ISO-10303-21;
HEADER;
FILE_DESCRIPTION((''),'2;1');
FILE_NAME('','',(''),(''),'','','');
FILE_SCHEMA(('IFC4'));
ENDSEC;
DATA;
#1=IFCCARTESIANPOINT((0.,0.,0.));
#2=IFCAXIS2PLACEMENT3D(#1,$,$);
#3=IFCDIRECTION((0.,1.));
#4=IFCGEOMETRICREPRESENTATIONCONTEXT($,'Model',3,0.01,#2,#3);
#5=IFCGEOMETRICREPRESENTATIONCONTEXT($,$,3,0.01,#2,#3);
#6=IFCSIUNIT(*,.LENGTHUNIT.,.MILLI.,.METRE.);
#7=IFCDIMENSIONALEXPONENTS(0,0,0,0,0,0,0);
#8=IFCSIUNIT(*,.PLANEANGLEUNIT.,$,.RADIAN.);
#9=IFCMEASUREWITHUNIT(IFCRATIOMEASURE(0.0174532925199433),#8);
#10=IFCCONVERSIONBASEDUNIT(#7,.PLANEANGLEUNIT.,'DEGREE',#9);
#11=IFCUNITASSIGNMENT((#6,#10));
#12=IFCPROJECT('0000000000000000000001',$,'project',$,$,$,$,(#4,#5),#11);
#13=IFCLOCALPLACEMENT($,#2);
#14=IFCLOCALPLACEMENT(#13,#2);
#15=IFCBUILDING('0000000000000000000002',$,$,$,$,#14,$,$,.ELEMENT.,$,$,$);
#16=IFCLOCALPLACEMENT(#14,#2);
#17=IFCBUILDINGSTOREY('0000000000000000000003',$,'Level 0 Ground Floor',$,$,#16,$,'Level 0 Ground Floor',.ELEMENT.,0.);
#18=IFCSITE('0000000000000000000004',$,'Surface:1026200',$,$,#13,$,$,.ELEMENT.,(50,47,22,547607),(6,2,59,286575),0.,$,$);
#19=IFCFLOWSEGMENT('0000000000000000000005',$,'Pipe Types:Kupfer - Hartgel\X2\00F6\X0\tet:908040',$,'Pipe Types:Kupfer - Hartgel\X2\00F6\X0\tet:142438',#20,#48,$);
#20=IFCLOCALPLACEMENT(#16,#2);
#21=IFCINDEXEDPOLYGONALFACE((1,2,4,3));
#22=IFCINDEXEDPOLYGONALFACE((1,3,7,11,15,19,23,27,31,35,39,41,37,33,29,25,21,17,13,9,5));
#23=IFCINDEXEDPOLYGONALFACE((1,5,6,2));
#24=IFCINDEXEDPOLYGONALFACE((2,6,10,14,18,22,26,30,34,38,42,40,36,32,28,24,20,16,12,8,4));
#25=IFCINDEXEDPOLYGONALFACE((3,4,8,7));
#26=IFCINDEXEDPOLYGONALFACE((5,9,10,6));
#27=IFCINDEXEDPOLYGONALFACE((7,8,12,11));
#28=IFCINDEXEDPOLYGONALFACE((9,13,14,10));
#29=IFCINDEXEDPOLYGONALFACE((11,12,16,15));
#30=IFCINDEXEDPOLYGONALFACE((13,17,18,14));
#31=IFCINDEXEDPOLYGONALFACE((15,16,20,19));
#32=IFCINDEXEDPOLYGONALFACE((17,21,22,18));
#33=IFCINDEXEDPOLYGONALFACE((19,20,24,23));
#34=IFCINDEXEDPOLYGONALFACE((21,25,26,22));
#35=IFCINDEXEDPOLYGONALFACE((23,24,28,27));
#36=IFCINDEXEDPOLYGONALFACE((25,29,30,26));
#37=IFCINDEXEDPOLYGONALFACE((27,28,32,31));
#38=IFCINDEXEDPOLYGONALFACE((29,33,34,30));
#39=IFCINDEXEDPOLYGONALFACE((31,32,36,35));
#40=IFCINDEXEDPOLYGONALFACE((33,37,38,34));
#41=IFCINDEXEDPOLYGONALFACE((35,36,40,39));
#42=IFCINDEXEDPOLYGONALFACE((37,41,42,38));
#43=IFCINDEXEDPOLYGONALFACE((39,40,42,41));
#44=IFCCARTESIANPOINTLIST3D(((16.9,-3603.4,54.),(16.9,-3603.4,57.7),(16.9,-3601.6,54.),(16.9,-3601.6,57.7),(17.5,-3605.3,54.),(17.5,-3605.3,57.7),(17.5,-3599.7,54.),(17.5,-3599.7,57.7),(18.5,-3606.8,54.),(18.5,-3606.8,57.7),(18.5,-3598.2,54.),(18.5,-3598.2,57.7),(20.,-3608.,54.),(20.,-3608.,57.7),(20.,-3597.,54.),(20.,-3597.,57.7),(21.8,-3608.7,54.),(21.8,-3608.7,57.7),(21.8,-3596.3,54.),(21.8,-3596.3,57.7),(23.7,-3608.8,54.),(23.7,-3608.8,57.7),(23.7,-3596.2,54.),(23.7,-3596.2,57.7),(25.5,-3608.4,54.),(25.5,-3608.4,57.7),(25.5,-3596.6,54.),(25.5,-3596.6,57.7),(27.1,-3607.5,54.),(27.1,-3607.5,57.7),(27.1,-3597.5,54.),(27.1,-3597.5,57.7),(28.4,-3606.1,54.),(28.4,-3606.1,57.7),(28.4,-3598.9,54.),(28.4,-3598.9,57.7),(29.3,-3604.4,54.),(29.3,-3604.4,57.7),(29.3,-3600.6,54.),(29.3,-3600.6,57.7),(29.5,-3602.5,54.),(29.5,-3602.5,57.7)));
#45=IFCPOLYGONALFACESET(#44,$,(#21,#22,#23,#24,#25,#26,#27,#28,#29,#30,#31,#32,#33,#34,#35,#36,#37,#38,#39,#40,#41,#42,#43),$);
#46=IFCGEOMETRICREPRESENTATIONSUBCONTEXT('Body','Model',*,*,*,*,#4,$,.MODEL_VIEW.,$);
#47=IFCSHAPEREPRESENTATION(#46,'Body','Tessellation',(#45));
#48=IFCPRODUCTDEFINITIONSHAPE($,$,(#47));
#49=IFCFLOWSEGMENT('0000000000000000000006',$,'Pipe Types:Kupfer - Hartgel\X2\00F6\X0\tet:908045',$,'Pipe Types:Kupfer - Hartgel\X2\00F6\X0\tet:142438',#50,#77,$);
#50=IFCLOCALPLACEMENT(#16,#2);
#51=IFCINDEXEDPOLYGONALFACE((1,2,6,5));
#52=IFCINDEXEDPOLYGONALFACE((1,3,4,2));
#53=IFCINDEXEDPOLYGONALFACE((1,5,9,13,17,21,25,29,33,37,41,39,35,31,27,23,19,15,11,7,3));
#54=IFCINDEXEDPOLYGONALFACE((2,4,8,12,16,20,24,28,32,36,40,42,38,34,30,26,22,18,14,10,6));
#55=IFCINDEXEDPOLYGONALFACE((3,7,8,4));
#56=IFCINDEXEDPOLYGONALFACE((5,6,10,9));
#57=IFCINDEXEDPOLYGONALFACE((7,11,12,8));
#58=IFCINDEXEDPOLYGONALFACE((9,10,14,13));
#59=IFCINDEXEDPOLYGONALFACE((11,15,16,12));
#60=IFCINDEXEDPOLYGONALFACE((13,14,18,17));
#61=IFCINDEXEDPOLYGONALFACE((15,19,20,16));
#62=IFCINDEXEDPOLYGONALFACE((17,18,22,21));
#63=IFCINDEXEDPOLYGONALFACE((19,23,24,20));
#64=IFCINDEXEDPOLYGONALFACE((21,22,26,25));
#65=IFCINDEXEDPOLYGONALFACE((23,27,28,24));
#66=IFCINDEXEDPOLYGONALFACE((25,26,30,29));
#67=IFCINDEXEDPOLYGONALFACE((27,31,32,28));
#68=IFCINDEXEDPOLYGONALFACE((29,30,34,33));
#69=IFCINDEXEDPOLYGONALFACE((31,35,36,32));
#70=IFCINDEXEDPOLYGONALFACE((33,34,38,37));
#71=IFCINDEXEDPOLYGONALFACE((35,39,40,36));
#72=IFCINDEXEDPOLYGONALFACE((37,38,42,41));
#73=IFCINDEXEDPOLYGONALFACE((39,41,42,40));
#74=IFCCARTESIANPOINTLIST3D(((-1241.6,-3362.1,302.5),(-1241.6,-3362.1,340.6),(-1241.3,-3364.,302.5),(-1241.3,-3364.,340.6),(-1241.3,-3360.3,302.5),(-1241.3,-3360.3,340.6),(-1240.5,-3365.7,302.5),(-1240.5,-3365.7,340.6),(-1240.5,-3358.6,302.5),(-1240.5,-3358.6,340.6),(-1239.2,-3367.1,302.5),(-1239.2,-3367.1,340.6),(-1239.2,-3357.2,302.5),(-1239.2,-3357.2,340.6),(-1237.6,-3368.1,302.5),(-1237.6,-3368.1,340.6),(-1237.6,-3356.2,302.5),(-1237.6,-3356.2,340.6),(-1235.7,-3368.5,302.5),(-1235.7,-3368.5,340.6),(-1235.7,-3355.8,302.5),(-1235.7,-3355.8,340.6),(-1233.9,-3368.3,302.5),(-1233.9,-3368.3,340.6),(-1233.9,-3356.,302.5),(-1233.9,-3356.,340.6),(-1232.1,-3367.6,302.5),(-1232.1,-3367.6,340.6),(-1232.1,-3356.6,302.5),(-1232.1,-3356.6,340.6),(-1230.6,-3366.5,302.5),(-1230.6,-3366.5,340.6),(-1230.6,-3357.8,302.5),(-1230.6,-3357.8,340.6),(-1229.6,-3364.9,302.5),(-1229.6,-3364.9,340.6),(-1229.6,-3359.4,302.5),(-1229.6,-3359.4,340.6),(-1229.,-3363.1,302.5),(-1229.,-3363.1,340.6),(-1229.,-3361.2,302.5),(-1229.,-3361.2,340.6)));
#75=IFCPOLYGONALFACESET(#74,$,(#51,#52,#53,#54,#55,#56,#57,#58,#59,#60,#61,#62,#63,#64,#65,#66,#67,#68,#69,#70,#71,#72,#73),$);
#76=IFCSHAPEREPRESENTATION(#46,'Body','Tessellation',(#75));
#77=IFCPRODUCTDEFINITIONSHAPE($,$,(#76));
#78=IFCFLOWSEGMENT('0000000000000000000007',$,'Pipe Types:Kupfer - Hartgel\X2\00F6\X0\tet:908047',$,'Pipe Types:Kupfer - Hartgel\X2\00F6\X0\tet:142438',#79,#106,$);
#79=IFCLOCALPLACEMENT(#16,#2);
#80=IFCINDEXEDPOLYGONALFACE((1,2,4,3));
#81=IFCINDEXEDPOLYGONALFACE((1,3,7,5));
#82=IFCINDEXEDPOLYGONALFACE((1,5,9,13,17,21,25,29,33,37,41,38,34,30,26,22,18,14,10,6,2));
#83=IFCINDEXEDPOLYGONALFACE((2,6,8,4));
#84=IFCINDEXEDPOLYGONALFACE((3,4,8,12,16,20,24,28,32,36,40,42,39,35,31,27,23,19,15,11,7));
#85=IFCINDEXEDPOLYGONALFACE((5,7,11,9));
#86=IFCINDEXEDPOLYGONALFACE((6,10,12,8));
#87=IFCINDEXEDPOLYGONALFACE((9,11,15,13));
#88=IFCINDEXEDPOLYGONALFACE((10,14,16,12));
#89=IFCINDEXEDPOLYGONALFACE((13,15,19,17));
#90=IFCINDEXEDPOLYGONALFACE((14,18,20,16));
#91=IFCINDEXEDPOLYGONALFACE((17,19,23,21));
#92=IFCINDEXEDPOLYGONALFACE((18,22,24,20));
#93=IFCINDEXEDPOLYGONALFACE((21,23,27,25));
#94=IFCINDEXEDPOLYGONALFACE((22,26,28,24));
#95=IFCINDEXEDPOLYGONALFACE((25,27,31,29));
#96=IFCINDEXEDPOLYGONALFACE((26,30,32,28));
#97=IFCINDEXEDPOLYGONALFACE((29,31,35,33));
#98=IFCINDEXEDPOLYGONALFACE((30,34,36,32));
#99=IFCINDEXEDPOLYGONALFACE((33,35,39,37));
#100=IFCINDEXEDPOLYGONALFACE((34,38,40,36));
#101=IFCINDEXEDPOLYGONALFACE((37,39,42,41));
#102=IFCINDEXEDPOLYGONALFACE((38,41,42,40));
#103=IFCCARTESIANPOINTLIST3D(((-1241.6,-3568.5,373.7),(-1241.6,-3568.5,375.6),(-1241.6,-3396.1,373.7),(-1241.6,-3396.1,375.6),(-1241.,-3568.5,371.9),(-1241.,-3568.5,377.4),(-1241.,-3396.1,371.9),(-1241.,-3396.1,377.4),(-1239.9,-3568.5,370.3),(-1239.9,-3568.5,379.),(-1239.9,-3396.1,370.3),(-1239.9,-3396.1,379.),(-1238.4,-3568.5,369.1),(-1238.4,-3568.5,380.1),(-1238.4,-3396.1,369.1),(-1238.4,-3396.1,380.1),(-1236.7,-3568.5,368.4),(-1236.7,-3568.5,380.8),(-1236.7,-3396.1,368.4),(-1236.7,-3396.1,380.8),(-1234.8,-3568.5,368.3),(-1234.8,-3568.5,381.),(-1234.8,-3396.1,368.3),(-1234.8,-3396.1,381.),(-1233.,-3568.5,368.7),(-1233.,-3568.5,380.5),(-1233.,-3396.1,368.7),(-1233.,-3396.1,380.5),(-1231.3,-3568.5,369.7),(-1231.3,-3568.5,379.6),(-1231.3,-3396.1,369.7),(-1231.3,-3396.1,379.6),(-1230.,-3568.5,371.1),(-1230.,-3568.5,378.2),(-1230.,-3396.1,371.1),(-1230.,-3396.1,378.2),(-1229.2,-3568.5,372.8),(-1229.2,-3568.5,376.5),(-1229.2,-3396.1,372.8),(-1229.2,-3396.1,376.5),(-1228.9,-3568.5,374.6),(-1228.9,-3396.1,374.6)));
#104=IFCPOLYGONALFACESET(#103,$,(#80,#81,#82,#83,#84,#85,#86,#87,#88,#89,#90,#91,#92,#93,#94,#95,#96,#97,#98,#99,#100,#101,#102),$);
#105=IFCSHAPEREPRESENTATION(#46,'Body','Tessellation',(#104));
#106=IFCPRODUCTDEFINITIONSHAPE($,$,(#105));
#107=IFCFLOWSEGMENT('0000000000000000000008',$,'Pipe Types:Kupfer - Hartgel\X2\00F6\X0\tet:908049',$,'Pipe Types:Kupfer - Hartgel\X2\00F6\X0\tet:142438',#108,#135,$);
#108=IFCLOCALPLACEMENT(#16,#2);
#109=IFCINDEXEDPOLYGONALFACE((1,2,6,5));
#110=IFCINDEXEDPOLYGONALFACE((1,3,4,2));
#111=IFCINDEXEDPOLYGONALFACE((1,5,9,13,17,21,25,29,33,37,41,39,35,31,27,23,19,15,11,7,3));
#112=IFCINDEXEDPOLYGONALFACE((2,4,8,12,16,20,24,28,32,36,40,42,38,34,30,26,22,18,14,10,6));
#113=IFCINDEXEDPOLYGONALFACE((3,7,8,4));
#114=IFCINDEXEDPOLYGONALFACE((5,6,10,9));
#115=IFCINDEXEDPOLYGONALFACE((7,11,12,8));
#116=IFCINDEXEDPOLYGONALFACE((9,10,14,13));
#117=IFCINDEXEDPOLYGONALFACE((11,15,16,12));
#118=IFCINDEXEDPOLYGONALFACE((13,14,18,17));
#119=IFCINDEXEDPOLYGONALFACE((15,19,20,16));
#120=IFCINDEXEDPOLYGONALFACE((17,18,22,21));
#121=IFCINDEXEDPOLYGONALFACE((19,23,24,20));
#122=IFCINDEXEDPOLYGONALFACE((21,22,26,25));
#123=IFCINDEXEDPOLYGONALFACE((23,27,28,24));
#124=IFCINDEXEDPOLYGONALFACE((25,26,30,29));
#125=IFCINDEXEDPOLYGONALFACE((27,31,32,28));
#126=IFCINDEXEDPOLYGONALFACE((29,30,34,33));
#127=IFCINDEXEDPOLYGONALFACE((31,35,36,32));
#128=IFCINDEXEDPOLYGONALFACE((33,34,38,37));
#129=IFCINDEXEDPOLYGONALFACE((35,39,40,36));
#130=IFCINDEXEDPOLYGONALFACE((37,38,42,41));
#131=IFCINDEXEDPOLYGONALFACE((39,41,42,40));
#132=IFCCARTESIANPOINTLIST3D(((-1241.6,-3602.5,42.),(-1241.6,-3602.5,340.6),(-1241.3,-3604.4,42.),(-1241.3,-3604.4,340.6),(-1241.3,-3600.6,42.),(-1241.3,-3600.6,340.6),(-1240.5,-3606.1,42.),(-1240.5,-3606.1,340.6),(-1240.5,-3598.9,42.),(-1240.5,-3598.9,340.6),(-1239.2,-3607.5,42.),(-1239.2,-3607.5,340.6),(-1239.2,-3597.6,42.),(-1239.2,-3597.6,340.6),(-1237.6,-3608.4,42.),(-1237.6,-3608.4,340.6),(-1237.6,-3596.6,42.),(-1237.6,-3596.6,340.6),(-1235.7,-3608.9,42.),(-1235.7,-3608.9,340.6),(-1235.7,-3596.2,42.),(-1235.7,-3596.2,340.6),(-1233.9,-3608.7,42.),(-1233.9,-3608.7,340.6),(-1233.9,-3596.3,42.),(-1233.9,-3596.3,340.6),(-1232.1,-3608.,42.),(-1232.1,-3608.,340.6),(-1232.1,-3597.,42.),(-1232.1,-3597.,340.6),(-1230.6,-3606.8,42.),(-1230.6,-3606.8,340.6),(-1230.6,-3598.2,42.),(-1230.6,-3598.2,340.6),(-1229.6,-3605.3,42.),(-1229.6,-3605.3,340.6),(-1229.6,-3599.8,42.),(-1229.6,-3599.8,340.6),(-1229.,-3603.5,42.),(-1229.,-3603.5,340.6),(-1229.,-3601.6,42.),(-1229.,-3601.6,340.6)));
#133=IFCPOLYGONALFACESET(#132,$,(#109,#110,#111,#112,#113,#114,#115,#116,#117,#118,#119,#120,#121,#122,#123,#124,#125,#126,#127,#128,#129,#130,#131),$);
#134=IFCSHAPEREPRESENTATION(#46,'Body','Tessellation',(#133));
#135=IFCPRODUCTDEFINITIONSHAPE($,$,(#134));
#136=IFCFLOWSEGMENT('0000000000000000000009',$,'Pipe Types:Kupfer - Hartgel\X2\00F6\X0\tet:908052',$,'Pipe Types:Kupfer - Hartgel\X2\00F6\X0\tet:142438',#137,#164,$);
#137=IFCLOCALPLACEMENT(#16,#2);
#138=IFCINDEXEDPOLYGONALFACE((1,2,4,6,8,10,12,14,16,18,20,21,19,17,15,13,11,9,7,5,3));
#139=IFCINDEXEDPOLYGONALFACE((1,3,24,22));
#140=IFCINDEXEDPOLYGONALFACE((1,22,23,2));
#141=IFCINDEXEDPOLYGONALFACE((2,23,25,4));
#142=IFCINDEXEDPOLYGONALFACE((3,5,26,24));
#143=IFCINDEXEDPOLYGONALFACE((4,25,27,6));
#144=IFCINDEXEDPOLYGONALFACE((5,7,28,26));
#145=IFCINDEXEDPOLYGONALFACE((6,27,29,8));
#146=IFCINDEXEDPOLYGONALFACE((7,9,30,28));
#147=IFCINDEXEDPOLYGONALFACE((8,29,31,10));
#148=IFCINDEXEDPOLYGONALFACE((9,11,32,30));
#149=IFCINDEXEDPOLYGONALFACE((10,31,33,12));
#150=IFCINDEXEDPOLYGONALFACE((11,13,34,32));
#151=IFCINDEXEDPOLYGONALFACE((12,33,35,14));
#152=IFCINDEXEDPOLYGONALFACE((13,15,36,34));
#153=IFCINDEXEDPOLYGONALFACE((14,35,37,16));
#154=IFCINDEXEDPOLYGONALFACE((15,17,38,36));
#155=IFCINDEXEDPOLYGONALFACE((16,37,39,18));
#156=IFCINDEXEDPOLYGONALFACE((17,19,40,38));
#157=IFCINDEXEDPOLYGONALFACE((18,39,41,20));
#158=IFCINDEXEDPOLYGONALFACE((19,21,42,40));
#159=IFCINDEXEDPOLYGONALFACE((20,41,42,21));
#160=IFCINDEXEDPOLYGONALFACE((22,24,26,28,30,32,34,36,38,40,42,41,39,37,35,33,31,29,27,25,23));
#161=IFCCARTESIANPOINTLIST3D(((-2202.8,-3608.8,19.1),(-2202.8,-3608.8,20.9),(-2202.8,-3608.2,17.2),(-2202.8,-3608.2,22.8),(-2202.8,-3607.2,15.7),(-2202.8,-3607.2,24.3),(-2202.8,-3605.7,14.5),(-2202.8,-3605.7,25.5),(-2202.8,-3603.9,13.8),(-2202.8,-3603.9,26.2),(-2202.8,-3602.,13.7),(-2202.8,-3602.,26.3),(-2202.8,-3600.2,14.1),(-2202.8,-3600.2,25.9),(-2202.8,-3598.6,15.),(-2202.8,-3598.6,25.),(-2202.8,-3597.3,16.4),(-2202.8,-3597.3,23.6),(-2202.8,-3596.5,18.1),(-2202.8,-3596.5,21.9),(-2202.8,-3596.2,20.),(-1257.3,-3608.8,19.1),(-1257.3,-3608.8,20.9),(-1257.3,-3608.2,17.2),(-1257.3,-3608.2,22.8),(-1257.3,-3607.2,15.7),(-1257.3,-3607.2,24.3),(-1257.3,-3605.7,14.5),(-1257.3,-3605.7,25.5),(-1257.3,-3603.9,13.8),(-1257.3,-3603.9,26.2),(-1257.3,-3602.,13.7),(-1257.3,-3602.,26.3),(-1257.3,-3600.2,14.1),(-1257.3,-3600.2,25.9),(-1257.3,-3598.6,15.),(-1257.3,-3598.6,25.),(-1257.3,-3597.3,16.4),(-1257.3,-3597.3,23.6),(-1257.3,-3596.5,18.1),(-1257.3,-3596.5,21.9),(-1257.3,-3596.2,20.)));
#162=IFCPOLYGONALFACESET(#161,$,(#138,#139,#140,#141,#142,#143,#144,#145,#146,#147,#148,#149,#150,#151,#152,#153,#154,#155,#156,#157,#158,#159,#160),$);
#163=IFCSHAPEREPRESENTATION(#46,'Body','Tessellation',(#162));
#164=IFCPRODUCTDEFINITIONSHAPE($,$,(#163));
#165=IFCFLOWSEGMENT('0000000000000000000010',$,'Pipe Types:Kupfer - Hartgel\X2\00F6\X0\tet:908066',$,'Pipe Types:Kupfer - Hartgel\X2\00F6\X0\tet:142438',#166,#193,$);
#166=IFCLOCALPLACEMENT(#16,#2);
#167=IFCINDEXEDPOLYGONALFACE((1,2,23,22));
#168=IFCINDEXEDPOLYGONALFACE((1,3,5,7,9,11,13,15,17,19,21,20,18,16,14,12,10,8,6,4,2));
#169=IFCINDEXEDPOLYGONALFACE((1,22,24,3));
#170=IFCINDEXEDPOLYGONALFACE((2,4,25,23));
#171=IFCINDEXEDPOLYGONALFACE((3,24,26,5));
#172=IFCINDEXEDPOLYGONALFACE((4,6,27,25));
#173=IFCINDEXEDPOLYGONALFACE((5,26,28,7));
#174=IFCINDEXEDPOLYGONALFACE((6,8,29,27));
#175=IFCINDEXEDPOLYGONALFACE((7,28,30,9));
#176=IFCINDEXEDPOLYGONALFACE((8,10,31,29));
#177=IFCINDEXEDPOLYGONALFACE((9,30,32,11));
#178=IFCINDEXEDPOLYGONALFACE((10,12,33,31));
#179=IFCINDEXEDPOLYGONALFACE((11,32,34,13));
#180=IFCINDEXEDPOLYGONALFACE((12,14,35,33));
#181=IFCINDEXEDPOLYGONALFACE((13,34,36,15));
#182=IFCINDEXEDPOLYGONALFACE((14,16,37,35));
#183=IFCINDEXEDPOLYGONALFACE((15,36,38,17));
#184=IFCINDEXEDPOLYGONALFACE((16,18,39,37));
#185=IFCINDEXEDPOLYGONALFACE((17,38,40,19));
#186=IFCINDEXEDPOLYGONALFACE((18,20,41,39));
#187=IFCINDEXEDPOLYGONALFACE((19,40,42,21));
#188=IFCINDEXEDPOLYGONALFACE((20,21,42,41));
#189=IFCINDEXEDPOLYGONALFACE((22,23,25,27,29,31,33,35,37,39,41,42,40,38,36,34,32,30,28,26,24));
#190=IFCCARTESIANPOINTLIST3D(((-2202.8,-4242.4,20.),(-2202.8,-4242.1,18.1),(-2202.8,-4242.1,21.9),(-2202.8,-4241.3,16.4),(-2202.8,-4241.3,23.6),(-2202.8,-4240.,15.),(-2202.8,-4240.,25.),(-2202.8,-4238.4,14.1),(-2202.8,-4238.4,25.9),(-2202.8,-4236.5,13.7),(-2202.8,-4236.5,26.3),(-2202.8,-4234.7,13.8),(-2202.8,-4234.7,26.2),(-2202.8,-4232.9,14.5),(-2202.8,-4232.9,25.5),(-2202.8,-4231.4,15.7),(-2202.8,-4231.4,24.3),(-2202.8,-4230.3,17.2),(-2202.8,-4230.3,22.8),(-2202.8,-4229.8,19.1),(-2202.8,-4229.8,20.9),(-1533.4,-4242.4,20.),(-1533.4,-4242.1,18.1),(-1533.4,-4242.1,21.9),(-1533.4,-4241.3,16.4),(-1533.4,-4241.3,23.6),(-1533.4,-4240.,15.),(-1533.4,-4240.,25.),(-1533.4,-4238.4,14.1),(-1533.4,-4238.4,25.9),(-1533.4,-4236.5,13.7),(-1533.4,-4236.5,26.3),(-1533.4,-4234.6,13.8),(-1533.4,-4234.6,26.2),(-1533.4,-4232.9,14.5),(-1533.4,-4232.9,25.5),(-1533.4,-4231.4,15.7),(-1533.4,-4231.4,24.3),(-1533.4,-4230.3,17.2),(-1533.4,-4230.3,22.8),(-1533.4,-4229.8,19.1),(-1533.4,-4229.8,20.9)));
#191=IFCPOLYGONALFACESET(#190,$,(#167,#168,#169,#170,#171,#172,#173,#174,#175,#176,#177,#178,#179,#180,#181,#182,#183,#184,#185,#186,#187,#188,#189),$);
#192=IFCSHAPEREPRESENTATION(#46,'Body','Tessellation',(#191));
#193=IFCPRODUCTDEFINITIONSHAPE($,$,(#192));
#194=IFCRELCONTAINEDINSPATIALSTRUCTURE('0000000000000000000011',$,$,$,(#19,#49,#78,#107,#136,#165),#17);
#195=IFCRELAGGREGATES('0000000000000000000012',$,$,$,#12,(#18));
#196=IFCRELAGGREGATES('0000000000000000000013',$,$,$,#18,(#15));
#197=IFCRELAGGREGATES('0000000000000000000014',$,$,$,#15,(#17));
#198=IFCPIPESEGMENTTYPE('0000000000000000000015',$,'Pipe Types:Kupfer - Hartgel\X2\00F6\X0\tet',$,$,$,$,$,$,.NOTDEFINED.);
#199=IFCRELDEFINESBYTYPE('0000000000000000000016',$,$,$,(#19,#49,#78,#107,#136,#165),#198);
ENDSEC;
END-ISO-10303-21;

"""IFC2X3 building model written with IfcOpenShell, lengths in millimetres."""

from ifc_helpers import new_model, entity, si_unit, converted_unit, direction, frame, frame_2d, origin, origin_2d_with_axis, place, context, subcontext, project, spatial, circle, extrude, type_object, element, save


model = new_model("IFC2X3")

# Units and contexts
model_context = context("Model", 3, precision=0.01, world=origin(), true_north=direction((0.0, 1.0)))
context_of_model = context(None, 3, precision=0.01, world=origin(), true_north=direction((0.0, 1.0)))
body_context = subcontext(model_context, "Body", "Model", "MODEL_VIEW")
ifc_project = project(units=[si_unit("LENGTHUNIT", "METRE", prefix="MILLI"), converted_unit("PLANEANGLEUNIT", "DEGREE", entity("IfcRatioMeasure", 0.0174532925199433), si_unit("PLANEANGLEUNIT", "RADIAN"), dimensions=[0, 0, 0, 0, 0, 0, 0])], contexts=[model_context, context_of_model])

# Site, building, storey
site_placement = place(None, origin())
site = spatial("IfcSite", under=ifc_project, at=site_placement, Name="Surface:1026200", CompositionType="ELEMENT", RefLatitude=(50, 47, 22, 547607), RefLongitude=(6, 2, 59, 286575), RefElevation=0.0)
building_placement = place(site_placement, origin())
building = spatial("IfcBuilding", under=site, at=building_placement, CompositionType="ELEMENT")
storey_placement = place(building_placement, origin())
storey = spatial("IfcBuildingStorey", under=building, at=storey_placement, Name="Level 0 Ground Floor", LongName="Level 0 Ground Floor", CompositionType="ELEMENT", Elevation=0.0)

# Flow segments
pipe_segment_type = type_object("IfcPipeSegmentType", Name="Pipe Types:Kupfer - Hartgelötet", PredefinedType="NOTDEFINED")
flow_segment_1_placement = place(storey_placement, origin())
element("IfcFlowSegment", 1, at=flow_segment_1_placement, inside=storey, type_object=pipe_segment_type, Name="Pipe Types:Kupfer - Hartgelötet:908040", ObjectType="Pipe Types:Kupfer - Hartgelötet:142438", context=body_context, shape_type="SweptSolid", body=[
    extrude(circle(Radius=6.3, at=frame_2d((0.0, 0.0), x_axis=(1.0, 0.0))), frame((23.2, -3602.5, 54.0)), (0.0, 0.0, 1.0), 3.7),
])
flow_segment_2_placement = place(storey_placement, origin())
element("IfcFlowSegment", 2, at=flow_segment_2_placement, inside=storey, type_object=pipe_segment_type, Name="Pipe Types:Kupfer - Hartgelötet:908045", ObjectType="Pipe Types:Kupfer - Hartgelötet:142438", context=body_context, shape_type="SweptSolid", body=[
    extrude(circle(Radius=6.3, at=origin_2d_with_axis()), frame((-1235.3, -3362.1, 302.5), z_axis=(0.0, 0.0, 1.0), x_axis=(-1.0, 0.0, 0.0)), (0.0, 0.0, 1.0), 38.1),
])
flow_segment_3_placement = place(storey_placement, origin())
element("IfcFlowSegment", 3, at=flow_segment_3_placement, inside=storey, type_object=pipe_segment_type, Name="Pipe Types:Kupfer - Hartgelötet:908047", ObjectType="Pipe Types:Kupfer - Hartgelötet:142438", context=body_context, shape_type="SweptSolid", body=[
    extrude(circle(Radius=6.3, at=frame_2d((0.0, 0.0), x_axis=(1.0, 0.0))), frame((-1235.3, -3568.5, 374.6), z_axis=(0.0, 1.0, 0.0), x_axis=(1.0, 0.0, 0.0)), (0.0, 0.0, 1.0), 172.4),
])
flow_segment_4_placement = place(storey_placement, origin())
element("IfcFlowSegment", 4, at=flow_segment_4_placement, inside=storey, type_object=pipe_segment_type, Name="Pipe Types:Kupfer - Hartgelötet:908049", ObjectType="Pipe Types:Kupfer - Hartgelötet:142438", context=body_context, shape_type="SweptSolid", body=[
    extrude(circle(Radius=6.3, at=frame_2d((0.0, 0.0), x_axis=(1.0, 0.0))), frame((-1235.3, -3602.5, 42.0), z_axis=(0.0, 0.0, 1.0), x_axis=(-1.0, 0.0, 0.0)), (0.0, 0.0, 1.0), 298.6),
])
flow_segment_5_placement = place(storey_placement, origin())
element("IfcFlowSegment", 5, at=flow_segment_5_placement, inside=storey, type_object=pipe_segment_type, Name="Pipe Types:Kupfer - Hartgelötet:908052", ObjectType="Pipe Types:Kupfer - Hartgelötet:142438", context=body_context, shape_type="SweptSolid", body=[
    extrude(circle(Radius=6.3, at=frame_2d((0.0, 0.0), x_axis=(1.0, 0.0))), frame((-2202.8, -3602.5, 20.0), z_axis=(1.0, 0.0, 0.0), x_axis=(0.0, 1.0, 0.0)), (0.0, 0.0, 1.0), 945.5),
])
flow_segment_6_placement = place(storey_placement, origin())
element("IfcFlowSegment", 6, at=flow_segment_6_placement, inside=storey, type_object=pipe_segment_type, Name="Pipe Types:Kupfer - Hartgelötet:908066", ObjectType="Pipe Types:Kupfer - Hartgelötet:142438", context=body_context, shape_type="SweptSolid", body=[
    extrude(circle(Radius=6.3, at=frame_2d((0.0, 0.0), x_axis=(1.0, 0.0))), frame((-2202.8, -4236.1, 20.0), z_axis=(1.0, 0.000044, 0.0), x_axis=(0.000044, -1.0, 0.0)), (0.0, 0.0, 1.0), 669.4),
])

save(model, "model.ifc")
